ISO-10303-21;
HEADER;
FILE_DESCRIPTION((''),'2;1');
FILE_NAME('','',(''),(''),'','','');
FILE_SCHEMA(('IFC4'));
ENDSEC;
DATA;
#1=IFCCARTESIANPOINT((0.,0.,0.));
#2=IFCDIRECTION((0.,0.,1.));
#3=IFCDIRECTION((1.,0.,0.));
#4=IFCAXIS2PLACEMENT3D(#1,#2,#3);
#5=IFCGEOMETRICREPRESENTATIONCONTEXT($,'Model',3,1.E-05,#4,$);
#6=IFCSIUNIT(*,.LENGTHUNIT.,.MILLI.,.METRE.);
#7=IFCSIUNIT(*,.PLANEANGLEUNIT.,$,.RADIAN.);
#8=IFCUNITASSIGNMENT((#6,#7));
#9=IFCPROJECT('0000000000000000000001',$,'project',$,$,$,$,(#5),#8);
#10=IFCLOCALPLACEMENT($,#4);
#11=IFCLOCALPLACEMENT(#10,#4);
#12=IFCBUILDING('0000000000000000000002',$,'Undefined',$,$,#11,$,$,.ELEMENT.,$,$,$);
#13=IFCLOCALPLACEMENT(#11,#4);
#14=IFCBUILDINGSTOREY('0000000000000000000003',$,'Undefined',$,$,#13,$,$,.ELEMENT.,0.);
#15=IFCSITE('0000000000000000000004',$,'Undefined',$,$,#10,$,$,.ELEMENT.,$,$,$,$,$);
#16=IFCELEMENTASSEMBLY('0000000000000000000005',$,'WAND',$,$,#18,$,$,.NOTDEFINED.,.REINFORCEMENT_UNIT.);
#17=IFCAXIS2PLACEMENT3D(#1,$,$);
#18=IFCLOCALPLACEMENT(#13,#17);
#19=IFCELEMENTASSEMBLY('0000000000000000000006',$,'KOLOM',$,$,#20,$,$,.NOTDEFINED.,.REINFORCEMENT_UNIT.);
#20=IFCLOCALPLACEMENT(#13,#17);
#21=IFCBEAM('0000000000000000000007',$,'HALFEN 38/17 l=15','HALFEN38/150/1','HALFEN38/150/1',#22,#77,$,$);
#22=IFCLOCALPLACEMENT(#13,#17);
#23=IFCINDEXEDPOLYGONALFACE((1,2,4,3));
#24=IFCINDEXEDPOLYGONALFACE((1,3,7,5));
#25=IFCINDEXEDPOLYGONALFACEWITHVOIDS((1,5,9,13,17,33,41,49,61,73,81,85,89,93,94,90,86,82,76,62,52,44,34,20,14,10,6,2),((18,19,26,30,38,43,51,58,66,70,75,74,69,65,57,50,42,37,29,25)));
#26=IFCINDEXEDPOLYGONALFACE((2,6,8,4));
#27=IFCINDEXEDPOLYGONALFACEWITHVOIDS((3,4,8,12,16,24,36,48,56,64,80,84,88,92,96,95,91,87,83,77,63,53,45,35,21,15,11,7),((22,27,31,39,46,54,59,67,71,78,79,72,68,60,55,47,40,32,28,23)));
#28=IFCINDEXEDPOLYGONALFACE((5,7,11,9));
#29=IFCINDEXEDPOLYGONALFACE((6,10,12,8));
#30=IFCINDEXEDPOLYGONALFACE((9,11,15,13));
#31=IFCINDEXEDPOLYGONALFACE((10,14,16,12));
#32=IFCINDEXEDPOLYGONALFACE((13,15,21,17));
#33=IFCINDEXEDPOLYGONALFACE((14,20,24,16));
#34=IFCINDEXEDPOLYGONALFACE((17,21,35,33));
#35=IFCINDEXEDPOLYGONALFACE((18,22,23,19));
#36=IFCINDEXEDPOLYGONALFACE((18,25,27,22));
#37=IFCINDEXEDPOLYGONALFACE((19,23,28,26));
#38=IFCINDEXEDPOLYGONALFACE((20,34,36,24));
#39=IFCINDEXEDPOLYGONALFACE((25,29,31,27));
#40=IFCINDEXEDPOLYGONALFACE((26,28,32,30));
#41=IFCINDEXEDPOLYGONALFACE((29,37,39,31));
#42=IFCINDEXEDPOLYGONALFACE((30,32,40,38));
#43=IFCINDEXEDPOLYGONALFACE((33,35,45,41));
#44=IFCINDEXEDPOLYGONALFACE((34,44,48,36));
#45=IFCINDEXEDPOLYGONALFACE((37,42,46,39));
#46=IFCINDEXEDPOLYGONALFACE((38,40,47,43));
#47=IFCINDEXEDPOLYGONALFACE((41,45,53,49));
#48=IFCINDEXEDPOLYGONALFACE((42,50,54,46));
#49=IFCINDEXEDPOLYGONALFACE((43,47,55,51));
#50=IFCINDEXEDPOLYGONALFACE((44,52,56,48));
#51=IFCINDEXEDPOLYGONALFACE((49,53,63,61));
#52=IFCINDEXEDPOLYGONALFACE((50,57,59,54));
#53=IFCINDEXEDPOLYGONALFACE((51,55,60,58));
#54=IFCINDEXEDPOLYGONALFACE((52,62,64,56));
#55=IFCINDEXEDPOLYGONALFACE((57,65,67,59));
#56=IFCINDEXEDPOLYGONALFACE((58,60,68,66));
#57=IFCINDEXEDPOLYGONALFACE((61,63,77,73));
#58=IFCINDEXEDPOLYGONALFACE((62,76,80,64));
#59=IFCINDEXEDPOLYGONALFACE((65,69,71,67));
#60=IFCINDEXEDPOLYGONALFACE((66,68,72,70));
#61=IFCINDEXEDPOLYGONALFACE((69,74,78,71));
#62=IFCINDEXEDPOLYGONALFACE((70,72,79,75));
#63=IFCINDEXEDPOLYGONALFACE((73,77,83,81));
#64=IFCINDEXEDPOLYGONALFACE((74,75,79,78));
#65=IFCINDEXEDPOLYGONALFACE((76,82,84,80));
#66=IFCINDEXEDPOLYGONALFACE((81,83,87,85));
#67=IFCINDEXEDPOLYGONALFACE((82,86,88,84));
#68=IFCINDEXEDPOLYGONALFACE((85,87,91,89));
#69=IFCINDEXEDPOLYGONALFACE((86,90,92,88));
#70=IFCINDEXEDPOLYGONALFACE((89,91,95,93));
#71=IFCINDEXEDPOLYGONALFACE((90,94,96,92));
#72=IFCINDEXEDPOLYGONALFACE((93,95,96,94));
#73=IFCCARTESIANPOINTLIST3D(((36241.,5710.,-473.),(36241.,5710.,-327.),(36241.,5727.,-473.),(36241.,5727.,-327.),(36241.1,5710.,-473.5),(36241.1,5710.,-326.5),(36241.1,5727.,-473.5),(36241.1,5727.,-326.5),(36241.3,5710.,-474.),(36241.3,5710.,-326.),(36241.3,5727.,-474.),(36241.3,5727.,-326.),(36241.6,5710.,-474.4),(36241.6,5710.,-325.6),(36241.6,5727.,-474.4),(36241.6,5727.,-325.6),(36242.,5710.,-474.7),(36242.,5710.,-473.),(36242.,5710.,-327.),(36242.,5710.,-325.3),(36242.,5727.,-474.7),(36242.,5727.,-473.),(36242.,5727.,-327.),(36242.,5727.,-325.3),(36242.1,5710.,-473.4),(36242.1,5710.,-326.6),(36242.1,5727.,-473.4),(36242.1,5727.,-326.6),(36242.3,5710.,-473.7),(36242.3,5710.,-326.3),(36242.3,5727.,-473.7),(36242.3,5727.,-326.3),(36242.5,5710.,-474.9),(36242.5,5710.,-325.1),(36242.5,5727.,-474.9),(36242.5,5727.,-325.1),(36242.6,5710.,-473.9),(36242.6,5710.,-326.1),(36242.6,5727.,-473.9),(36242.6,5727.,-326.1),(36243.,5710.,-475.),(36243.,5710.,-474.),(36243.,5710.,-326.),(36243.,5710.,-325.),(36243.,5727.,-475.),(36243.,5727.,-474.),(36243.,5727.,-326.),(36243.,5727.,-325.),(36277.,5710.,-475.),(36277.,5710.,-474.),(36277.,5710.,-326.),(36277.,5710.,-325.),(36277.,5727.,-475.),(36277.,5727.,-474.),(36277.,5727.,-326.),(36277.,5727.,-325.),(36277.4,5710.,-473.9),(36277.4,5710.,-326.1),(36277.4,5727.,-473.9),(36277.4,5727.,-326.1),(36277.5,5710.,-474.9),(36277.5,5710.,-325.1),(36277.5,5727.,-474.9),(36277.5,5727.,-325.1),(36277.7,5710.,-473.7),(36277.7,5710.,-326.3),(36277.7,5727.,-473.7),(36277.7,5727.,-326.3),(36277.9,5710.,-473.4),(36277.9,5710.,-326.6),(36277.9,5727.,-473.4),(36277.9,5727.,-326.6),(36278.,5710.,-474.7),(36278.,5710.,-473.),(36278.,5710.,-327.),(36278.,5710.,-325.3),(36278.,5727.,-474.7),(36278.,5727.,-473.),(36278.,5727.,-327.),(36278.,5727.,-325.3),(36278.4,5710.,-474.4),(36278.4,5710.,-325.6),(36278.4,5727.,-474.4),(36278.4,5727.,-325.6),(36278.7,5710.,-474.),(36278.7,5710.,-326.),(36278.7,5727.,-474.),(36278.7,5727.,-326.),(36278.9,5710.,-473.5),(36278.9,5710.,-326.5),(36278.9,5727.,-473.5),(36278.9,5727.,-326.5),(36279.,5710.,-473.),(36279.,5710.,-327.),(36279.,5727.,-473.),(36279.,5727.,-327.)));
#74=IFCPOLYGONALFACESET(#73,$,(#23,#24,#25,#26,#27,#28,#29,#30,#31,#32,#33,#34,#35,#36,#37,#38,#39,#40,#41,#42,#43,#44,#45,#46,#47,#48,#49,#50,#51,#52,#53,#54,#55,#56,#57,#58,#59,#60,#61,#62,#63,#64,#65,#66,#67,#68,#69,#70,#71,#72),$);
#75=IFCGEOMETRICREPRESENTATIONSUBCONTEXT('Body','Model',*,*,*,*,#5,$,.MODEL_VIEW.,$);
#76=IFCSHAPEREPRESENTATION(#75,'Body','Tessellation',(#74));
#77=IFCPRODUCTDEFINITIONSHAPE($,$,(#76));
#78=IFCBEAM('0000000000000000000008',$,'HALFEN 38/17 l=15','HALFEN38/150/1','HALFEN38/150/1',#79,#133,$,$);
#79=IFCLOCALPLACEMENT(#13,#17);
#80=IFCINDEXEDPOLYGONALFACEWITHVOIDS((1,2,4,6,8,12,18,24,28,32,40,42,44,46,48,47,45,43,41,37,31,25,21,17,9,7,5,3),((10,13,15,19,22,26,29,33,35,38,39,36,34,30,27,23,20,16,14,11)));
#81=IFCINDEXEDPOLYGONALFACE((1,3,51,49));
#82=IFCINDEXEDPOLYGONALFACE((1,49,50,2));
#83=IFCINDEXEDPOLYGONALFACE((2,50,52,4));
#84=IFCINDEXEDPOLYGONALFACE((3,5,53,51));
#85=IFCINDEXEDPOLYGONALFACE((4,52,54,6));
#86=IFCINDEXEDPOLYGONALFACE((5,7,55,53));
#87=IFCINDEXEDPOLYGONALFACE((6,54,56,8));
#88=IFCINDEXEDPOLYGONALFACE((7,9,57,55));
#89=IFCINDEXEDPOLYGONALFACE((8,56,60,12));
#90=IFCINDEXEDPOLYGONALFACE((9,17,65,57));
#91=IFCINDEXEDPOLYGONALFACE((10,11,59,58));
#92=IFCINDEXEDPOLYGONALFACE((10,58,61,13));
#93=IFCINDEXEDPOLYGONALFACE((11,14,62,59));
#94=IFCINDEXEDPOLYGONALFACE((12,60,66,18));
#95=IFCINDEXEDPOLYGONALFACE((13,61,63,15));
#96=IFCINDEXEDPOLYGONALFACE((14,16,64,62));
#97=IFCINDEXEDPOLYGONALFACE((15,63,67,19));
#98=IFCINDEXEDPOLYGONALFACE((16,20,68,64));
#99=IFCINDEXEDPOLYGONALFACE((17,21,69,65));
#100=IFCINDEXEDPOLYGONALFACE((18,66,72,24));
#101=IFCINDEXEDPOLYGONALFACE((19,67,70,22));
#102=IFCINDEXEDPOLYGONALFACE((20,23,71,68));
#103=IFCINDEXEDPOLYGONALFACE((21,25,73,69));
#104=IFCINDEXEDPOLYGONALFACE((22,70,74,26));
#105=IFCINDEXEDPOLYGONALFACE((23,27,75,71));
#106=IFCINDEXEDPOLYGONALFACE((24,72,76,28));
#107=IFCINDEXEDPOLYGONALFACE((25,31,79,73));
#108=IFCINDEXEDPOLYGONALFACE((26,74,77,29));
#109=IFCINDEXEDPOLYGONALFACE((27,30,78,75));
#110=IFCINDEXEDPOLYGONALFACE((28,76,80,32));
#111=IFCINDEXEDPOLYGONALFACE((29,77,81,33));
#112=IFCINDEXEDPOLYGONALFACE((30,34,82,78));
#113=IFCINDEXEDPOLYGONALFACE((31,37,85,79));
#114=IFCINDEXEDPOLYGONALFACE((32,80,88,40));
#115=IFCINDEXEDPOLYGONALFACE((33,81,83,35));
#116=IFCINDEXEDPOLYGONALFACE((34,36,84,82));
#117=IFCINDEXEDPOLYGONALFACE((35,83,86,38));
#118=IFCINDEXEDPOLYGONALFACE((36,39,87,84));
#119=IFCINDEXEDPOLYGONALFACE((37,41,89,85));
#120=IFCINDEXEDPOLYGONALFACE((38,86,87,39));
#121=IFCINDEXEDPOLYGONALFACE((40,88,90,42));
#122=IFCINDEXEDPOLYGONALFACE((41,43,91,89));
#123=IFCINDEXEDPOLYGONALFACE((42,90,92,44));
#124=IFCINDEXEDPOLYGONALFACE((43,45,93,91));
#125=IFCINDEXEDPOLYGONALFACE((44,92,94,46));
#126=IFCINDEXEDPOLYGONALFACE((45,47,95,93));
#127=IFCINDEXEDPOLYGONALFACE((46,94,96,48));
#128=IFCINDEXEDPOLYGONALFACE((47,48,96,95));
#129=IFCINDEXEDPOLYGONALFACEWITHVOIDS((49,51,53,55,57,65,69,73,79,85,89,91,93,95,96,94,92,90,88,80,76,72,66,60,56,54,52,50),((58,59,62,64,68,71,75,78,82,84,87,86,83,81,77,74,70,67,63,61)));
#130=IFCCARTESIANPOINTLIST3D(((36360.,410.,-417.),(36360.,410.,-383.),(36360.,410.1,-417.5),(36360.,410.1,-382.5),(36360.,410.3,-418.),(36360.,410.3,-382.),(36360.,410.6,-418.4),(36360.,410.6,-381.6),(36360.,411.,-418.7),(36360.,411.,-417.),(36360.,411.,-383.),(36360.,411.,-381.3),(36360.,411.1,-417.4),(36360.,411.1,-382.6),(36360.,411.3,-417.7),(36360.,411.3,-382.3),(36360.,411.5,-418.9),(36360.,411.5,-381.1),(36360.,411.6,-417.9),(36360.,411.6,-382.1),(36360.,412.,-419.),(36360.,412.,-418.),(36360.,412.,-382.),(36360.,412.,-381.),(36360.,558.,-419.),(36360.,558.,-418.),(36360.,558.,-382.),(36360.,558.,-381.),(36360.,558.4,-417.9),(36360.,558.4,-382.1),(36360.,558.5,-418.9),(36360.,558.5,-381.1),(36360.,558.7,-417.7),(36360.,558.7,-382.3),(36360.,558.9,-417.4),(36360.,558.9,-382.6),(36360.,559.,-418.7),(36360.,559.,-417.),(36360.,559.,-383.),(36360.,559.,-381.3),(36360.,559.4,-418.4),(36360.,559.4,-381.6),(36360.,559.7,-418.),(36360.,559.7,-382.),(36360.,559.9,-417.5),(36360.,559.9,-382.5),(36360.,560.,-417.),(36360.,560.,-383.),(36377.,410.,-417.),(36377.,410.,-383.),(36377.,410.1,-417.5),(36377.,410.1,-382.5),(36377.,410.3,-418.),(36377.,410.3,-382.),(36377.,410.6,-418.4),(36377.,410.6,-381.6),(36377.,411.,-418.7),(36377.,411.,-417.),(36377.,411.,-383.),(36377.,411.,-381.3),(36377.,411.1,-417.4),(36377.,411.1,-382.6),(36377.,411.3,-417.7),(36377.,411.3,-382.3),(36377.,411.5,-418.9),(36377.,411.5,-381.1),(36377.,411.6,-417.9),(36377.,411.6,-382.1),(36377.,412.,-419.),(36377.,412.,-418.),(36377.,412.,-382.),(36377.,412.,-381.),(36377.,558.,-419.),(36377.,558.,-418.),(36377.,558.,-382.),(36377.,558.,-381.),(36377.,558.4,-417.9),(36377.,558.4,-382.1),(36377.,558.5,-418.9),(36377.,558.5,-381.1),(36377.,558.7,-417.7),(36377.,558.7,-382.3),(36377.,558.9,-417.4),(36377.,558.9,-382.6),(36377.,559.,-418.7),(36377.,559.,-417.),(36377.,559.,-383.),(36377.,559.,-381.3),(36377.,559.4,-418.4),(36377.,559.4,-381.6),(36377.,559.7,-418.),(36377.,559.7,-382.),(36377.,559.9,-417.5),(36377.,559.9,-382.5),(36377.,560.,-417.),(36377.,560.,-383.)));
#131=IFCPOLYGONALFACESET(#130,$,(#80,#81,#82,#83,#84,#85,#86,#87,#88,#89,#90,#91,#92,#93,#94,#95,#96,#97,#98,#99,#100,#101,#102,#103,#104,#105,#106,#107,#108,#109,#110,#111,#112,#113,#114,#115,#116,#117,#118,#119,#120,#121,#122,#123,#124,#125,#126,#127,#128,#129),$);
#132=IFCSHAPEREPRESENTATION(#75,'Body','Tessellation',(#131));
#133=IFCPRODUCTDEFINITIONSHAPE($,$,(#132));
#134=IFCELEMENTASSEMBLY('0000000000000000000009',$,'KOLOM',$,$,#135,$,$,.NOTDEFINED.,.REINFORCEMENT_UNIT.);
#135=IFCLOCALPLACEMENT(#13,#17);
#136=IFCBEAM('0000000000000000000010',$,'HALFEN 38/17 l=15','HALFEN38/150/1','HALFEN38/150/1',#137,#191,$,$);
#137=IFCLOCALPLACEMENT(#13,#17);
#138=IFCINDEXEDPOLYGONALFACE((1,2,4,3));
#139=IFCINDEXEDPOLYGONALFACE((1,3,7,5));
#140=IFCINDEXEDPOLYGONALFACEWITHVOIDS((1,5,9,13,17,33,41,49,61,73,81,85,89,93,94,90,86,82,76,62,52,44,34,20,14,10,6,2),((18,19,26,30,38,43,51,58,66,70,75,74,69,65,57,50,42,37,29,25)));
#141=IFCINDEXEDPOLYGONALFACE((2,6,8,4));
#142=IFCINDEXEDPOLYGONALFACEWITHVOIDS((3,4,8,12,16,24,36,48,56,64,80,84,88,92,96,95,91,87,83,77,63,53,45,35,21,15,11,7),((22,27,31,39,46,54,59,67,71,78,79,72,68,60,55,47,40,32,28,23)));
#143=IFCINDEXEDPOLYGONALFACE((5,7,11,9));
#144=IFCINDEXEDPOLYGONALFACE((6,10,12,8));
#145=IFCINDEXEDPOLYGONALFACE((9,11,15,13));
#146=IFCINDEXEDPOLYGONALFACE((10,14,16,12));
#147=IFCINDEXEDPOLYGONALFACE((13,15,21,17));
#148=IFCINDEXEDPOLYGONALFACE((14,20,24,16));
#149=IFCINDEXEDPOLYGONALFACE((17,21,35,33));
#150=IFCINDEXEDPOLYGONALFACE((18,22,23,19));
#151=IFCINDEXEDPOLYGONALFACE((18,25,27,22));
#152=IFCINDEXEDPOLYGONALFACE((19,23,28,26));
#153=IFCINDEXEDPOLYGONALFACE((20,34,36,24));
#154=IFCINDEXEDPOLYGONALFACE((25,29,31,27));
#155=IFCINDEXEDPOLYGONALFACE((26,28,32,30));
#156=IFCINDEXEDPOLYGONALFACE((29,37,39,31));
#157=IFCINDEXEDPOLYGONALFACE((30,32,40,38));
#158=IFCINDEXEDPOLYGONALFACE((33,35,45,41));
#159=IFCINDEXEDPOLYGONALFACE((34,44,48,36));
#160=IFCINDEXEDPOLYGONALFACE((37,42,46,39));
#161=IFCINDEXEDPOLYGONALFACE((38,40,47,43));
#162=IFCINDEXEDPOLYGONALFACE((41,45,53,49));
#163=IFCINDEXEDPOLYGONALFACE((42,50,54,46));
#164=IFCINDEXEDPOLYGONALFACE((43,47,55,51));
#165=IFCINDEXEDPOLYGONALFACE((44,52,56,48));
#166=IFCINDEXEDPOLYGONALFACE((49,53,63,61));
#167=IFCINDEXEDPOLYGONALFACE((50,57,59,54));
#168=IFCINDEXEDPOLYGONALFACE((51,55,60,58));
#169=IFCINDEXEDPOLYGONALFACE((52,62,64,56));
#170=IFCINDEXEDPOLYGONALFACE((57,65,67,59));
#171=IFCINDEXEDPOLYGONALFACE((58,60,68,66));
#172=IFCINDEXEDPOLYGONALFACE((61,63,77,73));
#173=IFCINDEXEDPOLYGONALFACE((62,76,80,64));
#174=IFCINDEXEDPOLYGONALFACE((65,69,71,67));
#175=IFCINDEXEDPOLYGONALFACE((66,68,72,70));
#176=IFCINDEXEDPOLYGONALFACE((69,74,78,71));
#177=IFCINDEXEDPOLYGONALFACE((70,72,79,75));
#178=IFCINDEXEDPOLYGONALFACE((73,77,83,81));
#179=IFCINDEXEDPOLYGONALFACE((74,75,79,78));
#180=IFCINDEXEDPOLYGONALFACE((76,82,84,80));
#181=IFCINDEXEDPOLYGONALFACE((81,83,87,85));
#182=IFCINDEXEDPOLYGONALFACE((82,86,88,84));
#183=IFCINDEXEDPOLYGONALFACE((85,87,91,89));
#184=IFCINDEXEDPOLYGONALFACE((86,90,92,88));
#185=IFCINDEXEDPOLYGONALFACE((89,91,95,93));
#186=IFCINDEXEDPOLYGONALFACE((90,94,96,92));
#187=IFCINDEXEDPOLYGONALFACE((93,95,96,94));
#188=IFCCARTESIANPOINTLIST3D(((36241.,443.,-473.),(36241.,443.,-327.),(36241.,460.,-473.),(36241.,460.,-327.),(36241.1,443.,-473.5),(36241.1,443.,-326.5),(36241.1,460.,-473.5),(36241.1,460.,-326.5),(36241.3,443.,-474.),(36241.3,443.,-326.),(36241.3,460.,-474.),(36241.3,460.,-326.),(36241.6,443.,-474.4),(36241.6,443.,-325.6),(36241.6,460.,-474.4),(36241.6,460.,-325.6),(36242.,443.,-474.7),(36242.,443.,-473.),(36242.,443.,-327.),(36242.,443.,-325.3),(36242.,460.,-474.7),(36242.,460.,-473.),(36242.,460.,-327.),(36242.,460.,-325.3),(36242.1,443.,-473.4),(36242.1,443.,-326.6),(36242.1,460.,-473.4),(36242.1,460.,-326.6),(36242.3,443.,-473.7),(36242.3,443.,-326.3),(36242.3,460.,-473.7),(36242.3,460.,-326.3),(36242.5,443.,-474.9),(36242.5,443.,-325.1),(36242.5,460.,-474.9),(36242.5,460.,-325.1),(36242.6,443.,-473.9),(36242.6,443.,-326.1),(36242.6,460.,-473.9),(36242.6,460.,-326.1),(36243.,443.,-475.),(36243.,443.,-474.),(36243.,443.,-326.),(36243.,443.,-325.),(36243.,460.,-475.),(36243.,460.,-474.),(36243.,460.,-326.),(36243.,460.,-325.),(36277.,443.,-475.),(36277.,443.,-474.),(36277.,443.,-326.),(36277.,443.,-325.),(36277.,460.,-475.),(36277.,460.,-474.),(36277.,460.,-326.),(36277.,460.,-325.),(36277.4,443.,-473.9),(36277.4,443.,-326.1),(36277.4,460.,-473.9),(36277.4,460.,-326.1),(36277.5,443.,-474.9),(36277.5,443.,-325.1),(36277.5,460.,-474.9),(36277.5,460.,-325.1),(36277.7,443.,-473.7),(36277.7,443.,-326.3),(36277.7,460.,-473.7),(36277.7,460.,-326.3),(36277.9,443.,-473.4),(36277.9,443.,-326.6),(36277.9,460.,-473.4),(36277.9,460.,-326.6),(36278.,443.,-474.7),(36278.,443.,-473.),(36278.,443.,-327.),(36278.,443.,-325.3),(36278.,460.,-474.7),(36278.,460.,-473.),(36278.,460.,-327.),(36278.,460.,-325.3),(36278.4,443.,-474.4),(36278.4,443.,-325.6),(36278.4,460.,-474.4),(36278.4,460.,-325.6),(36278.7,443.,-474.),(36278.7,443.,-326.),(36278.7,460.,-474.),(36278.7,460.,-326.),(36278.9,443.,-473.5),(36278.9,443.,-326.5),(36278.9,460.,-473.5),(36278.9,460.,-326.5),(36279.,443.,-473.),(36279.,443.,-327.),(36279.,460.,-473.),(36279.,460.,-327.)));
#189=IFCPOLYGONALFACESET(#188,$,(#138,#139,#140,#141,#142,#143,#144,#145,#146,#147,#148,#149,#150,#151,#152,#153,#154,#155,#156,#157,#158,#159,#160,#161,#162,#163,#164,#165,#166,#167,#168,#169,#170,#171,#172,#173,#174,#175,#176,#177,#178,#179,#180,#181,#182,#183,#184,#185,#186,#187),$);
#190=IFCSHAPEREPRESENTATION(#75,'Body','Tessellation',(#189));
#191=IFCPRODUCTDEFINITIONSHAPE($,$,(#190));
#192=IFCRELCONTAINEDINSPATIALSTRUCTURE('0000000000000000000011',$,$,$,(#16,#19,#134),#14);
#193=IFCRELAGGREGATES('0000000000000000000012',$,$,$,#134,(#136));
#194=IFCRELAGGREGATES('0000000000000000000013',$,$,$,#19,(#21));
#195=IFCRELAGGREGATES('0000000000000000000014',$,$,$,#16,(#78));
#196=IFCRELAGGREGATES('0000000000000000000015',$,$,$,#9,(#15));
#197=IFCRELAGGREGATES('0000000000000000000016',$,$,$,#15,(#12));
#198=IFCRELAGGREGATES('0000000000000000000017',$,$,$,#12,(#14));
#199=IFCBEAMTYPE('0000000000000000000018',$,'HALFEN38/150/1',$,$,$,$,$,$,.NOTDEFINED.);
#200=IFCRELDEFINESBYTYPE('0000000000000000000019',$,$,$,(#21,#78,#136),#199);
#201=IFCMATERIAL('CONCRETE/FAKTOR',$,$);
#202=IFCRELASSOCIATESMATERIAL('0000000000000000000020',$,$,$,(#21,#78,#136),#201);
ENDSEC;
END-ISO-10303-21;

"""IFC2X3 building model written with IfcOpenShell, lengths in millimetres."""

from ifc_helpers import new_model, si_unit, frame, frame_2d, origin_with_axes, place, context, subcontext, project, spatial, hollow_rectangle, extrude, material, type_object, element, aggregate, save


model = new_model("IFC2X3")

# Units and contexts
model_context = context("Model", 3, precision=1e-05, world=origin_with_axes())
body_context = subcontext(model_context, "Body", "Model", "MODEL_VIEW")
ifc_project = project(units=[si_unit("LENGTHUNIT", "METRE", prefix="MILLI"), si_unit("PLANEANGLEUNIT", "RADIAN")], contexts=[model_context])

# Site, building, storey
site_placement = place(None, origin_with_axes())
site = spatial("IfcSite", under=ifc_project, at=site_placement, Name="Undefined", CompositionType="ELEMENT")
building_placement = place(site_placement, origin_with_axes())
building = spatial("IfcBuilding", under=site, at=building_placement, Name="Undefined", CompositionType="ELEMENT")
storey_placement = place(building_placement, origin_with_axes())
storey = spatial("IfcBuildingStorey", under=building, at=storey_placement, Name="Undefined", CompositionType="ELEMENT", Elevation=0.0)

# Element assemblies, beam
ifc_material_1 = material(Name="CONCRETE/FAKTOR")
assembly_1_placement = place(storey_placement, origin_with_axes())
assembly_1 = element("IfcElementAssembly", 1, at=assembly_1_placement, inside=storey, Name="WAND", AssemblyPlace="NOTDEFINED", PredefinedType="REINFORCEMENT_UNIT")
beam_type_1 = type_object("IfcBeamType", Name="HALFEN38/150/1", PredefinedType="NOTDEFINED")
assembly_2_placement = place(storey_placement, origin_with_axes())
assembly_2 = element("IfcElementAssembly", 2, at=assembly_2_placement, inside=storey, Name="KOLOM", AssemblyPlace="NOTDEFINED", PredefinedType="REINFORCEMENT_UNIT")
beam_1_placement = place(assembly_2_placement, frame((36260.0, 5710.0, -400.0), z_axis=(-1.0, 0.0, 0.0), x_axis=(0.0, 1.0, 0.0)))
beam_1 = element("IfcBeam", 3, at=beam_1_placement, type_object=beam_type_1, material=ifc_material_1, Name="HALFEN 38/17 l=15", Description="HALFEN38/150/1", ObjectType="HALFEN38/150/1", context=body_context, shape_type="SweptSolid", body=[
    extrude(hollow_rectangle(XDim=150.0, YDim=38.0, WallThickness=1.0, InnerFilletRadius=1.0, OuterFilletRadius=2.0, at=frame_2d((0.0, 0.0), x_axis=(1.0, 0.0))), frame((17.0, 0.0, 0.0), z_axis=(-1.0, 0.0, 0.0), x_axis=(0.0, -1.0, 0.0)), (0.0, 0.0, 1.0), 17.0),
])

# Beam
beam_2_placement = place(assembly_1_placement, frame((36360.0, 485.0, -400.0), z_axis=(0.0, 0.0, -1.0), x_axis=(1.0, 0.0, 0.0)))
beam_2 = element("IfcBeam", 4, at=beam_2_placement, type_object=beam_type_1, material=ifc_material_1, Name="HALFEN 38/17 l=15", Description="HALFEN38/150/1", ObjectType="HALFEN38/150/1", context=body_context, shape_type="SweptSolid", body=[
    extrude(hollow_rectangle(XDim=150.0, YDim=38.0, WallThickness=1.0, InnerFilletRadius=1.0, OuterFilletRadius=2.0, at=frame_2d((0.0, 0.0), x_axis=(1.0, 0.0))), frame((17.0, 0.0, 0.0), z_axis=(-1.0, 0.0, 0.0), x_axis=(0.0, -1.0, 0.0)), (0.0, 0.0, 1.0), 17.0),
])

# Element assembly, beam
assembly_3_placement = place(storey_placement, origin_with_axes())
assembly_3 = element("IfcElementAssembly", 5, at=assembly_3_placement, inside=storey, Name="KOLOM", AssemblyPlace="NOTDEFINED", PredefinedType="REINFORCEMENT_UNIT")
beam_3_placement = place(assembly_3_placement, frame((36260.0, 460.0, -400.0), z_axis=(-1.0, 0.0, 0.0), x_axis=(0.0, -1.0, 0.0)))
beam_3 = element("IfcBeam", 6, at=beam_3_placement, type_object=beam_type_1, material=ifc_material_1, Name="HALFEN 38/17 l=15", Description="HALFEN38/150/1", ObjectType="HALFEN38/150/1", context=body_context, shape_type="SweptSolid", body=[
    extrude(hollow_rectangle(XDim=150.0, YDim=38.0, WallThickness=1.0, InnerFilletRadius=1.0, OuterFilletRadius=2.0, at=frame_2d((0.0, 0.0), x_axis=(1.0, 0.0))), frame((17.0, 0.0, 0.0), z_axis=(-1.0, 0.0, 0.0), x_axis=(0.0, -1.0, 0.0)), (0.0, 0.0, 1.0), 17.0),
])
aggregate(assembly_3, [beam_3])

aggregate(assembly_2, [beam_1])

aggregate(assembly_1, [beam_2])

save(model, "model.ifc")
